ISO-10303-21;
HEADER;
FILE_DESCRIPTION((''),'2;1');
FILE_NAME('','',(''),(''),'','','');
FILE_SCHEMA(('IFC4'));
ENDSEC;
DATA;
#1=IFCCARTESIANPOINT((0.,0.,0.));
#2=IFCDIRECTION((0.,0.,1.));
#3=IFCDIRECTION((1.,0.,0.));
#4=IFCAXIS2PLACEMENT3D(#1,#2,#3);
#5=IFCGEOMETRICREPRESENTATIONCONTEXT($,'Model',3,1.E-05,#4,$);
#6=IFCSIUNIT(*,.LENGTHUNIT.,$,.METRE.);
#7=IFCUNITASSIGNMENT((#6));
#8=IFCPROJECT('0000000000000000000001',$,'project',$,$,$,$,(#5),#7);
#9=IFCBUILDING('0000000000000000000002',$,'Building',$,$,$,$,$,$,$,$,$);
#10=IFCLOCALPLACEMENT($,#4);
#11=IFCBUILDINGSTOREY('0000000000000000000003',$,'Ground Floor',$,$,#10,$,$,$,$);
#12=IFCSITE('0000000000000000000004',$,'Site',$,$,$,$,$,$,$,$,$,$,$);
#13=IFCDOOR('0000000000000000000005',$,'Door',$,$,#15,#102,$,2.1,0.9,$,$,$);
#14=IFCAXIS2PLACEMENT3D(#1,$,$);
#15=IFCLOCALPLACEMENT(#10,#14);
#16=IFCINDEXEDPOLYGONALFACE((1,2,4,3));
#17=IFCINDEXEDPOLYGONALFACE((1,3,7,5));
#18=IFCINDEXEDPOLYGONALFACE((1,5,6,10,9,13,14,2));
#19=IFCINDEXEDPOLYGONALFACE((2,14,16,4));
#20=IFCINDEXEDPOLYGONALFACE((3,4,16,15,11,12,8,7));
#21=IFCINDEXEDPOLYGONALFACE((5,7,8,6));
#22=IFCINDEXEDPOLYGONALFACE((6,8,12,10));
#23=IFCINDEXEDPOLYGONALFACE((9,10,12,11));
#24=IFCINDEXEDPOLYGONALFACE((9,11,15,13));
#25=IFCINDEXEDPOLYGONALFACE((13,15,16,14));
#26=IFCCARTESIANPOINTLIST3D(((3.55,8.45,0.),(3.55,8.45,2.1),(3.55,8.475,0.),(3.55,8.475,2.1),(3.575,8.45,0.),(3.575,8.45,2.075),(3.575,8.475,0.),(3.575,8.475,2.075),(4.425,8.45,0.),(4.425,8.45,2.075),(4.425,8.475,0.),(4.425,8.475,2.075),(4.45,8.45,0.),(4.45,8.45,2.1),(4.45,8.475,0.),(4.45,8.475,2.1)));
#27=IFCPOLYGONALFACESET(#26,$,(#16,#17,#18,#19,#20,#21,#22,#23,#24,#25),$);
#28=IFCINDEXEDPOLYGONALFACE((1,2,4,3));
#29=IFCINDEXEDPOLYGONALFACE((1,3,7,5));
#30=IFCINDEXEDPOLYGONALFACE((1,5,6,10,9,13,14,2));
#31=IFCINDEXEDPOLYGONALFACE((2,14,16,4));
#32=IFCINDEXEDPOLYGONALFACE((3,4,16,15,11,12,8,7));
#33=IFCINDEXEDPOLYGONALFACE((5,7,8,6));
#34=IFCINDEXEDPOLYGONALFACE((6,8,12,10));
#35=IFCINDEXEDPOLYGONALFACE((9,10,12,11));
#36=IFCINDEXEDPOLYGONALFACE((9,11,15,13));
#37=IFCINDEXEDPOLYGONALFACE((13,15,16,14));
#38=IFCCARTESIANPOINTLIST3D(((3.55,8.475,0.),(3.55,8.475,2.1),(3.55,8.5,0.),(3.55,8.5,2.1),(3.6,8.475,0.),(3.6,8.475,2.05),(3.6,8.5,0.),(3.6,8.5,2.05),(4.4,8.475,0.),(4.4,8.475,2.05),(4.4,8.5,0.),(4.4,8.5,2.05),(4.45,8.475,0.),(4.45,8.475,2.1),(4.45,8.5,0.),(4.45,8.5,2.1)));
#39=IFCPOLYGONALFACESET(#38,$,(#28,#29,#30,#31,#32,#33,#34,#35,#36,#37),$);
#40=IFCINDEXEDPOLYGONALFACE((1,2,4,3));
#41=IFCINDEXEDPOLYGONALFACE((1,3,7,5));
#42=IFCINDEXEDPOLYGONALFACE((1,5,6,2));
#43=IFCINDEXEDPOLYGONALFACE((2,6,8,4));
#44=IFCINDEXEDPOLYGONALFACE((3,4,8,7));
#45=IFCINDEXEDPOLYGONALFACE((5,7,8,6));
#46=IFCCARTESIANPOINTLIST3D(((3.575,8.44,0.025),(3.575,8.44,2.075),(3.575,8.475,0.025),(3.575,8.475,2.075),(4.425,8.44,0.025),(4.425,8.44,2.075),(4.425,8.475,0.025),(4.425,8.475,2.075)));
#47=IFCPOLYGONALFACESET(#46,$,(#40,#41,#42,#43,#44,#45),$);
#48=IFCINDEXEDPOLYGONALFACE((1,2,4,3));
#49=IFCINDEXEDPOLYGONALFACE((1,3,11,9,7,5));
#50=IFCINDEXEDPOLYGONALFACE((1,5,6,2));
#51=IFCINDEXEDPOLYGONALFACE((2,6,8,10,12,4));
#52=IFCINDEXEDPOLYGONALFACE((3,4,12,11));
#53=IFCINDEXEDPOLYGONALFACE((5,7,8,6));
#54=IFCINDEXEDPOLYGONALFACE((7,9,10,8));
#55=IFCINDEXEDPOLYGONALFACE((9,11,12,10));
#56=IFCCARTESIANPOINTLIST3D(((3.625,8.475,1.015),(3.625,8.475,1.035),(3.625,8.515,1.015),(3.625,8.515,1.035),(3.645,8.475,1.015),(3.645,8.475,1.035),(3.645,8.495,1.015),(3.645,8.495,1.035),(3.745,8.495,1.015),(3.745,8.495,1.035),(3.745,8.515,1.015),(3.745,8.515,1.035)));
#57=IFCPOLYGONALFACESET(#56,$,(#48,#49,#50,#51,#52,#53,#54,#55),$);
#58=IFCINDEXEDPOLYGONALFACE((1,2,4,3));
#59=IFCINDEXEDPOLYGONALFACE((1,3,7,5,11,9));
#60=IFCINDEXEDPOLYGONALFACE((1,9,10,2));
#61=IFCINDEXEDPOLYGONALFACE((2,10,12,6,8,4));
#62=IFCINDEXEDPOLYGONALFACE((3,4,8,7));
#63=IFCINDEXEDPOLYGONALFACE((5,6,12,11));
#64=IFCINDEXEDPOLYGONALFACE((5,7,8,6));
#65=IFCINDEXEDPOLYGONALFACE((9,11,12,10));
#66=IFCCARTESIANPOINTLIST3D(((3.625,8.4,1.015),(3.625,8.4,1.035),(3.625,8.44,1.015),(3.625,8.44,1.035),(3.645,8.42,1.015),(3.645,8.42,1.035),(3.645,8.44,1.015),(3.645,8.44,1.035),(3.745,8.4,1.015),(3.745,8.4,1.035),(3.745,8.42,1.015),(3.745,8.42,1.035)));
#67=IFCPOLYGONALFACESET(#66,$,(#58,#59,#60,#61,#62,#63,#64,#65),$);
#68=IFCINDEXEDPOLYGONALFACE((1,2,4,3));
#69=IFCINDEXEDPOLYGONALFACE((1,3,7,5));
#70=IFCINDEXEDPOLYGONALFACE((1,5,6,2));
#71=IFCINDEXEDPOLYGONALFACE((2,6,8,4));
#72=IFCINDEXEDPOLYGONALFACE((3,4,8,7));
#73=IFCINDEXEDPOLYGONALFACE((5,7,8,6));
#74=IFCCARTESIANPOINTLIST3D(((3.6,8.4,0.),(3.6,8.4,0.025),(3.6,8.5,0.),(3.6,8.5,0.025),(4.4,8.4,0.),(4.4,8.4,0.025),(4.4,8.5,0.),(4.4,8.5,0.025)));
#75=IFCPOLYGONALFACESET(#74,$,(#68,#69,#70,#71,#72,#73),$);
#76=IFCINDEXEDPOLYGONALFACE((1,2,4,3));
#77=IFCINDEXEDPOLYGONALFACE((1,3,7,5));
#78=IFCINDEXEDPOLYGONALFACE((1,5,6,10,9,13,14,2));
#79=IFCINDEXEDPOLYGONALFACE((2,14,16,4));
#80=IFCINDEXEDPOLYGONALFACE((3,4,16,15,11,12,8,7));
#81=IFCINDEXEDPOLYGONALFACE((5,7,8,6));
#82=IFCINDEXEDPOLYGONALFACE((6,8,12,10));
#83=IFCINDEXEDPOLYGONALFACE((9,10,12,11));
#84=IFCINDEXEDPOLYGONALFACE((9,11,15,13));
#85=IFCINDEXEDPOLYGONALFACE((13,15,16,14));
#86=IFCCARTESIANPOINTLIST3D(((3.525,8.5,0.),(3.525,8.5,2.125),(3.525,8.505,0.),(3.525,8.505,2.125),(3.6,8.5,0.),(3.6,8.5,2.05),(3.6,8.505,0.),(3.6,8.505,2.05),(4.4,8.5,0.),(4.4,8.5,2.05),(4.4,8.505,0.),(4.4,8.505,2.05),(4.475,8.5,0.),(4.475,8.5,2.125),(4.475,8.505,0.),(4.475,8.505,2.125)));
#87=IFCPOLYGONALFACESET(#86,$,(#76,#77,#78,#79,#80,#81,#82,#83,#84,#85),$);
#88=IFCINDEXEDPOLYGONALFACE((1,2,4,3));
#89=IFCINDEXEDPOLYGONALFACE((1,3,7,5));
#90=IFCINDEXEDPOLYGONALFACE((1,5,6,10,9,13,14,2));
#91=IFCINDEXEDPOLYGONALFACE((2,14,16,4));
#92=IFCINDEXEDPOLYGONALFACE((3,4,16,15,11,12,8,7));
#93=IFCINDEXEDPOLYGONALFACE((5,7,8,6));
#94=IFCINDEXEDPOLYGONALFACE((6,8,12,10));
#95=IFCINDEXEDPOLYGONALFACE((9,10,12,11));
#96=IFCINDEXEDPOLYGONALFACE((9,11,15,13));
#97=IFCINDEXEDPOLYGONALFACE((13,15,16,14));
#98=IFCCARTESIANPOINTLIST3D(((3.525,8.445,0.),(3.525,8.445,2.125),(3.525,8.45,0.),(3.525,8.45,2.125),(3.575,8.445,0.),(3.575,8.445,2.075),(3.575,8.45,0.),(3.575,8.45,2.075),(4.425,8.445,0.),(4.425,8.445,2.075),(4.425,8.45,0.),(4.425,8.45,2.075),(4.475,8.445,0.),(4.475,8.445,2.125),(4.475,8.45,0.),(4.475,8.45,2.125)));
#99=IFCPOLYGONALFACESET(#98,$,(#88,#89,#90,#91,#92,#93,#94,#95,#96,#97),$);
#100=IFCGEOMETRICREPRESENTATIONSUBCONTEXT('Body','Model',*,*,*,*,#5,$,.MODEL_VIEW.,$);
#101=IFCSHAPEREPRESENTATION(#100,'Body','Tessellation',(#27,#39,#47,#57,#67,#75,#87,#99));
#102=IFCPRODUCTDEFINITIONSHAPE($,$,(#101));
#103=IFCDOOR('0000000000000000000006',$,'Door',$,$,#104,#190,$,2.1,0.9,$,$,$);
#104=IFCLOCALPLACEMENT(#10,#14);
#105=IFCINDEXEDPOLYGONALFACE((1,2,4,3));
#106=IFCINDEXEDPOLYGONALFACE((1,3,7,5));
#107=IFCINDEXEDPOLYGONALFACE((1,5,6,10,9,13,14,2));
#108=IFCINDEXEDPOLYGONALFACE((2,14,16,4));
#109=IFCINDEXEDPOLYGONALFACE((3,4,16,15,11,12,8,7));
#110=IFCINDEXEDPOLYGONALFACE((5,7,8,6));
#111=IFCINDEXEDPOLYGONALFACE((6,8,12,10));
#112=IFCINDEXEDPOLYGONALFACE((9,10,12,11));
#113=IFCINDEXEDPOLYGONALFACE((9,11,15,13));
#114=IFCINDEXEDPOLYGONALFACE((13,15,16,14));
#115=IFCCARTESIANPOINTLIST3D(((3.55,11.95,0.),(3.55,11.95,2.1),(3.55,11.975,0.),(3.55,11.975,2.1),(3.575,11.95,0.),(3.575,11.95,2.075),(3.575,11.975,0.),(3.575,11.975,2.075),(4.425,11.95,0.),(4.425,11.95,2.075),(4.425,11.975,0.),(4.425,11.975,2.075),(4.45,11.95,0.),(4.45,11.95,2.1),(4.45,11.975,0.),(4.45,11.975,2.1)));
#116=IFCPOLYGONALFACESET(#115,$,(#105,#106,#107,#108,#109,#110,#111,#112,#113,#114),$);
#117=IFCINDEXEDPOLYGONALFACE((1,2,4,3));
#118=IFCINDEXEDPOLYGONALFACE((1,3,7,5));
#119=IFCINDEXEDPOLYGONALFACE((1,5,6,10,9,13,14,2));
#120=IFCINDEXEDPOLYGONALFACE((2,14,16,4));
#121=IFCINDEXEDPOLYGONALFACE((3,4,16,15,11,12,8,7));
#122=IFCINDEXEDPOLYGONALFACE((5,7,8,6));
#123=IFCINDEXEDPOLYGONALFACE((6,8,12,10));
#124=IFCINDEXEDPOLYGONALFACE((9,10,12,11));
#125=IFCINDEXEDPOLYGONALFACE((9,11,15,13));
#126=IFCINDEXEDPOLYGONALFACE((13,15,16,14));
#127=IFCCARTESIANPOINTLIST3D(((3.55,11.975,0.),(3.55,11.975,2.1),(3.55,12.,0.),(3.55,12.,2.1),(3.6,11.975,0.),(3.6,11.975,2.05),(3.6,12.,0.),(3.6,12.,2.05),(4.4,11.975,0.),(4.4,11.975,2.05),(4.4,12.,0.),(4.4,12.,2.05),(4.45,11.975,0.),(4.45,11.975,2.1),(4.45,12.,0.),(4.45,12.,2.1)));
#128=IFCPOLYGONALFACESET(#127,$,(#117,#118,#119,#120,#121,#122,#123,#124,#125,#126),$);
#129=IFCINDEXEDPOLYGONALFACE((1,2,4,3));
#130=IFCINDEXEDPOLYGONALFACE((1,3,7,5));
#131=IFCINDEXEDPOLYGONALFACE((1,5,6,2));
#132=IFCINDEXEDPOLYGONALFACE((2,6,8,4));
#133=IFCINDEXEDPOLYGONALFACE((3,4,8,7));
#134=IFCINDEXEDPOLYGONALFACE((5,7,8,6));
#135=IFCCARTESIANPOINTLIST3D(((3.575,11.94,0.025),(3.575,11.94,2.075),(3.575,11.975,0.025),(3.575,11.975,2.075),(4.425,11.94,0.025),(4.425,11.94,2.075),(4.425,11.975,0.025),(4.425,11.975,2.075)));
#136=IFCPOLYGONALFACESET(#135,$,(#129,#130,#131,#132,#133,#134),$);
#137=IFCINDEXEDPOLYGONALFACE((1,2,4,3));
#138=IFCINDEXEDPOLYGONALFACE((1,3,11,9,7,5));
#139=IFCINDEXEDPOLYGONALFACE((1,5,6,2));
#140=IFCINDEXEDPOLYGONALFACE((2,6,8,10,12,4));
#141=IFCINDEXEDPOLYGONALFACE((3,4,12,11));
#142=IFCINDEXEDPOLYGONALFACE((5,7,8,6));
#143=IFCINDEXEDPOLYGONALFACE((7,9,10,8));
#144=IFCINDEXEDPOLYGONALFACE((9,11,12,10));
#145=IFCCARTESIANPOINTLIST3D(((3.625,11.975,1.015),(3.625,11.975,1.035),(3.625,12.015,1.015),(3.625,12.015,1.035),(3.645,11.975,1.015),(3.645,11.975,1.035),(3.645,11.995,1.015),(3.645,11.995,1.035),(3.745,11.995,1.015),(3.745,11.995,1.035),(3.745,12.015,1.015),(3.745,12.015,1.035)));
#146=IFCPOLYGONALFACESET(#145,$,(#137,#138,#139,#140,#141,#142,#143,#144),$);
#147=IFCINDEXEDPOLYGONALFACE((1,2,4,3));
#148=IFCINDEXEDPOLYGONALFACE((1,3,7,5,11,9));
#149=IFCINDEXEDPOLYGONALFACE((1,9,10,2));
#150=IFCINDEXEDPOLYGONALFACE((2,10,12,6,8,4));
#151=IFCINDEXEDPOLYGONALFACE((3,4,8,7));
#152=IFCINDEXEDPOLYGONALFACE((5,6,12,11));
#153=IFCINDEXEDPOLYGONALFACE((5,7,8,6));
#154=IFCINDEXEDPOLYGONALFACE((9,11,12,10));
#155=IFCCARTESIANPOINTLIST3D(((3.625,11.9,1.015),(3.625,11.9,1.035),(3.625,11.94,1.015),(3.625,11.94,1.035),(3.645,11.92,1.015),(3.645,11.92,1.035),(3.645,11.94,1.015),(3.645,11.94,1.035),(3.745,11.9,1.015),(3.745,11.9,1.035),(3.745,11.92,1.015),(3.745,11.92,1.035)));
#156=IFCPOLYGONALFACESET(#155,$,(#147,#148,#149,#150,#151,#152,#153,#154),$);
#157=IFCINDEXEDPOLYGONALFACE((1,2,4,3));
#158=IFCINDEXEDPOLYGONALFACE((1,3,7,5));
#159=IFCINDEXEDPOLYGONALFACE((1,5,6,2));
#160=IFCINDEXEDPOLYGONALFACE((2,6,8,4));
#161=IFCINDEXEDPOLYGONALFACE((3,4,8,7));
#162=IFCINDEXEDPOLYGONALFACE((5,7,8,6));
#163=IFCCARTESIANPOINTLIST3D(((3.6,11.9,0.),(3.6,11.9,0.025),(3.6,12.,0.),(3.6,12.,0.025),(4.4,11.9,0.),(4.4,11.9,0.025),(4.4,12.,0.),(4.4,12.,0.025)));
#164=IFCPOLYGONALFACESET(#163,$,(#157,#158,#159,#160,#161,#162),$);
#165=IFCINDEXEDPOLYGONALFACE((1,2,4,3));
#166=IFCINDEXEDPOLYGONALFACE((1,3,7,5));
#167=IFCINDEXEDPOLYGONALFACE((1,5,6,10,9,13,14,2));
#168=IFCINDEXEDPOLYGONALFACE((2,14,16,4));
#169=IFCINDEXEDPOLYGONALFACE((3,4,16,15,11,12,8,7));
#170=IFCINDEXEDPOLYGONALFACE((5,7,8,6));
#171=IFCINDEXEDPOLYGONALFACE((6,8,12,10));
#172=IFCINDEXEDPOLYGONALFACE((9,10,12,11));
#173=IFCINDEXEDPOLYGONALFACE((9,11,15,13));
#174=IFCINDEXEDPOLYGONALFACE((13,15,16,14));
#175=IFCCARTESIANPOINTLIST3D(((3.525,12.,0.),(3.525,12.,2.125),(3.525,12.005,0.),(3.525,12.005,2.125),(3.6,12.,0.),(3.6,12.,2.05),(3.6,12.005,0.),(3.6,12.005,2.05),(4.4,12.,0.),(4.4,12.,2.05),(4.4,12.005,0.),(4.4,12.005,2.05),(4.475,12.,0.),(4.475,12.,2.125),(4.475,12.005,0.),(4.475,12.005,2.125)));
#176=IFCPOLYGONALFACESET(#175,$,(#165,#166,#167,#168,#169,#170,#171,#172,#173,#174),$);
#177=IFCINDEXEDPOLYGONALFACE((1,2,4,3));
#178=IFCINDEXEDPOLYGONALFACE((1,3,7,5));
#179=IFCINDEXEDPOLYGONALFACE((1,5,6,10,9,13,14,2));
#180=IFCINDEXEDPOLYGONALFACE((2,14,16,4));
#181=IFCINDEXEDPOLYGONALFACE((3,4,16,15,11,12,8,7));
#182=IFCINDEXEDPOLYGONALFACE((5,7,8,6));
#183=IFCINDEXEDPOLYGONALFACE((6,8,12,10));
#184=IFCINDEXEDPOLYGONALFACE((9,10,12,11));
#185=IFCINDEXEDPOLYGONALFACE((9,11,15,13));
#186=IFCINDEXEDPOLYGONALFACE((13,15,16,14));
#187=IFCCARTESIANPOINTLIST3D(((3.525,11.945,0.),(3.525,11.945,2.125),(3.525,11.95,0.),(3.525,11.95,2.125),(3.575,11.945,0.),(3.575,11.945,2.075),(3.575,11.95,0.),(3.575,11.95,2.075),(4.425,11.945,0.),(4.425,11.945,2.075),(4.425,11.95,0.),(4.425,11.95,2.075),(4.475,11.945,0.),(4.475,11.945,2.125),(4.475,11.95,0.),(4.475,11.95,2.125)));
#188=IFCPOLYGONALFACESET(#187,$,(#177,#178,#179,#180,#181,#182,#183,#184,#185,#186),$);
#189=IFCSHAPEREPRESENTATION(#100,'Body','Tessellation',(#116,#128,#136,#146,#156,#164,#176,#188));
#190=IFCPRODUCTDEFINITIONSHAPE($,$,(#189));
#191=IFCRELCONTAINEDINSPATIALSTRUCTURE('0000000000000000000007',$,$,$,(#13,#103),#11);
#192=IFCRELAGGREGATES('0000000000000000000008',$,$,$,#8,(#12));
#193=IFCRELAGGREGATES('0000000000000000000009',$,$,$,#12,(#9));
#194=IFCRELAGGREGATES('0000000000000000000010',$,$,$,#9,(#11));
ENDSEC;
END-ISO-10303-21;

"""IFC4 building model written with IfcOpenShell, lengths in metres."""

from ifc_helpers import new_model, si_unit, frame, origin_with_axes, place, context, subcontext, project, spatial, line, indexed_curve, outline, extrude, element, save


model = new_model("IFC4")

# Units and contexts
model_context = context("Model", 3, precision=1e-05, world=origin_with_axes())
body_context = subcontext(model_context, "Body", "Model", "MODEL_VIEW")
ifc_project = project(units=[si_unit("LENGTHUNIT", "METRE")], contexts=[model_context])

# Site, building, storey
site = spatial("IfcSite", under=ifc_project, Name="Site")
building = spatial("IfcBuilding", under=site, Name="Building")
storey_placement = place(None, origin_with_axes())
storey = spatial("IfcBuildingStorey", under=building, at=storey_placement, Name="Ground Floor")

# Doors
door_1_placement = place(storey_placement, frame((4.45, 8.5, 0.0), z_axis=(0.0, 0.0, 1.0), x_axis=(-1.0, 0.0, 0.0)))
element("IfcDoor", 1, at=door_1_placement, inside=storey, Name="Door", OverallHeight=2.1, OverallWidth=0.9, context=body_context, shape_type="SweptSolid", body=[
    extrude(outline(indexed_curve([(0.0, 0.0), (0.0, 2.1), (0.9, 2.1), (0.9, 0.0), (0.875, 0.0), (0.875, 2.075), (0.025, 2.075), (0.025, 0.0)], segments=[line(1, 2, 3, 4, 5, 6, 7, 8, 1)])), frame((0.0, 0.025, 0.0), z_axis=(0.0, -1.0, 0.0), x_axis=(1.0, 0.0, 0.0)), (0.0, 0.0, -1.0), 0.025),
    extrude(outline(indexed_curve([(0.0, 0.0), (0.0, 2.1), (0.9, 2.1), (0.9, 0.0), (0.85, 0.0), (0.85, 2.05), (0.05, 2.05), (0.05, 0.0)], segments=[line(1, 2, 3, 4, 5, 6, 7, 8, 1)])), frame((0.0, 0.0, 0.0), z_axis=(0.0, -1.0, 0.0), x_axis=(1.0, 0.0, 0.0)), (0.0, 0.0, -1.0), 0.025),
    extrude(outline(indexed_curve([(0.0, 0.0), (0.85, 0.0), (0.85, 0.035), (0.0, 0.035)], segments=[line(1, 2, 3, 4, 1)])), frame((0.025, 0.025, 0.025), z_axis=(0.0, 0.0, 1.0), x_axis=(1.0, 0.0, 0.0)), (0.0, 0.0, 1.0), 2.05),
    extrude(outline(indexed_curve([(0.0, 0.0), (0.0, -0.04), (-0.12, -0.04), (-0.12, -0.02), (-0.02, -0.02), (-0.02, 0.0)], segments=[line(1, 2, 3, 4, 5, 6, 1)])), frame((0.825, 0.025, 1.015), z_axis=(0.0, 0.0, 1.0), x_axis=(1.0, 0.0, 0.0)), (0.0, 0.0, 1.0), 0.02),
    extrude(outline(indexed_curve([(0.0, 0.0), (0.0, 0.04), (-0.12, 0.04), (-0.12, 0.02), (-0.02, 0.02), (-0.02, 0.0)], segments=[line(1, 2, 3, 4, 5, 6, 1)])), frame((0.825, 0.06, 1.015), z_axis=(0.0, 0.0, 1.0), x_axis=(1.0, 0.0, 0.0)), (0.0, 0.0, 1.0), 0.02),
    extrude(outline(indexed_curve([(0.0, 0.0), (0.8, 0.0), (0.8, 0.1), (0.0, 0.1)], segments=[line(1, 2, 3, 4, 1)])), frame((0.05, 0.0, 0.0), z_axis=(0.0, 0.0, 1.0), x_axis=(1.0, 0.0, 0.0)), (0.0, 0.0, 1.0), 0.025),
    extrude(outline(indexed_curve([(0.0, 0.0), (0.0, 2.125), (0.95, 2.125), (0.95, 0.0), (0.875, 0.0), (0.875, 2.05), (0.075, 2.05), (0.075, 0.0)], segments=[line(1, 2, 3, 4, 5, 6, 7, 8, 1)])), frame((-0.025, -0.005, 0.0), z_axis=(0.0, -1.0, 0.0), x_axis=(1.0, 0.0, 0.0)), (0.0, 0.0, -1.0), 0.005),
    extrude(outline(indexed_curve([(0.0, 0.0), (0.0, 2.125), (0.95, 2.125), (0.95, 0.0), (0.9, 0.0), (0.9, 2.075), (0.05, 2.075), (0.05, 0.0)], segments=[line(1, 2, 3, 4, 5, 6, 7, 8, 1)])), frame((-0.025, 0.05, 0.0), z_axis=(0.0, -1.0, 0.0), x_axis=(1.0, 0.0, 0.0)), (0.0, 0.0, -1.0), 0.005),
])
door_2_placement = place(storey_placement, frame((4.45, 12.0, 0.0), z_axis=(0.0, 0.0, 1.0), x_axis=(-1.0, 0.0, 0.0)))
element("IfcDoor", 2, at=door_2_placement, inside=storey, Name="Door", OverallHeight=2.1, OverallWidth=0.9, context=body_context, shape_type="SweptSolid", body=[
    extrude(outline(indexed_curve([(0.0, 0.0), (0.0, 2.1), (0.9, 2.1), (0.9, 0.0), (0.875, 0.0), (0.875, 2.075), (0.025, 2.075), (0.025, 0.0)], segments=[line(1, 2, 3, 4, 5, 6, 7, 8, 1)])), frame((0.0, 0.025, 0.0), z_axis=(0.0, -1.0, 0.0), x_axis=(1.0, 0.0, 0.0)), (0.0, 0.0, -1.0), 0.025),
    extrude(outline(indexed_curve([(0.0, 0.0), (0.0, 2.1), (0.9, 2.1), (0.9, 0.0), (0.85, 0.0), (0.85, 2.05), (0.05, 2.05), (0.05, 0.0)], segments=[line(1, 2, 3, 4, 5, 6, 7, 8, 1)])), frame((0.0, 0.0, 0.0), z_axis=(0.0, -1.0, 0.0), x_axis=(1.0, 0.0, 0.0)), (0.0, 0.0, -1.0), 0.025),
    extrude(outline(indexed_curve([(0.0, 0.0), (0.85, 0.0), (0.85, 0.035), (0.0, 0.035)], segments=[line(1, 2, 3, 4, 1)])), frame((0.025, 0.025, 0.025), z_axis=(0.0, 0.0, 1.0), x_axis=(1.0, 0.0, 0.0)), (0.0, 0.0, 1.0), 2.05),
    extrude(outline(indexed_curve([(0.0, 0.0), (0.0, -0.04), (-0.12, -0.04), (-0.12, -0.02), (-0.02, -0.02), (-0.02, 0.0)], segments=[line(1, 2, 3, 4, 5, 6, 1)])), frame((0.825, 0.025, 1.015), z_axis=(0.0, 0.0, 1.0), x_axis=(1.0, 0.0, 0.0)), (0.0, 0.0, 1.0), 0.02),
    extrude(outline(indexed_curve([(0.0, 0.0), (0.0, 0.04), (-0.12, 0.04), (-0.12, 0.02), (-0.02, 0.02), (-0.02, 0.0)], segments=[line(1, 2, 3, 4, 5, 6, 1)])), frame((0.825, 0.06, 1.015), z_axis=(0.0, 0.0, 1.0), x_axis=(1.0, 0.0, 0.0)), (0.0, 0.0, 1.0), 0.02),
    extrude(outline(indexed_curve([(0.0, 0.0), (0.8, 0.0), (0.8, 0.1), (0.0, 0.1)], segments=[line(1, 2, 3, 4, 1)])), frame((0.05, 0.0, 0.0), z_axis=(0.0, 0.0, 1.0), x_axis=(1.0, 0.0, 0.0)), (0.0, 0.0, 1.0), 0.025),
    extrude(outline(indexed_curve([(0.0, 0.0), (0.0, 2.125), (0.95, 2.125), (0.95, 0.0), (0.875, 0.0), (0.875, 2.05), (0.075, 2.05), (0.075, 0.0)], segments=[line(1, 2, 3, 4, 5, 6, 7, 8, 1)])), frame((-0.025, -0.005, 0.0), z_axis=(0.0, -1.0, 0.0), x_axis=(1.0, 0.0, 0.0)), (0.0, 0.0, -1.0), 0.005),
    extrude(outline(indexed_curve([(0.0, 0.0), (0.0, 2.125), (0.95, 2.125), (0.95, 0.0), (0.9, 0.0), (0.9, 2.075), (0.05, 2.075), (0.05, 0.0)], segments=[line(1, 2, 3, 4, 5, 6, 7, 8, 1)])), frame((-0.025, 0.05, 0.0), z_axis=(0.0, -1.0, 0.0), x_axis=(1.0, 0.0, 0.0)), (0.0, 0.0, -1.0), 0.005),
])

save(model, "model.ifc")
